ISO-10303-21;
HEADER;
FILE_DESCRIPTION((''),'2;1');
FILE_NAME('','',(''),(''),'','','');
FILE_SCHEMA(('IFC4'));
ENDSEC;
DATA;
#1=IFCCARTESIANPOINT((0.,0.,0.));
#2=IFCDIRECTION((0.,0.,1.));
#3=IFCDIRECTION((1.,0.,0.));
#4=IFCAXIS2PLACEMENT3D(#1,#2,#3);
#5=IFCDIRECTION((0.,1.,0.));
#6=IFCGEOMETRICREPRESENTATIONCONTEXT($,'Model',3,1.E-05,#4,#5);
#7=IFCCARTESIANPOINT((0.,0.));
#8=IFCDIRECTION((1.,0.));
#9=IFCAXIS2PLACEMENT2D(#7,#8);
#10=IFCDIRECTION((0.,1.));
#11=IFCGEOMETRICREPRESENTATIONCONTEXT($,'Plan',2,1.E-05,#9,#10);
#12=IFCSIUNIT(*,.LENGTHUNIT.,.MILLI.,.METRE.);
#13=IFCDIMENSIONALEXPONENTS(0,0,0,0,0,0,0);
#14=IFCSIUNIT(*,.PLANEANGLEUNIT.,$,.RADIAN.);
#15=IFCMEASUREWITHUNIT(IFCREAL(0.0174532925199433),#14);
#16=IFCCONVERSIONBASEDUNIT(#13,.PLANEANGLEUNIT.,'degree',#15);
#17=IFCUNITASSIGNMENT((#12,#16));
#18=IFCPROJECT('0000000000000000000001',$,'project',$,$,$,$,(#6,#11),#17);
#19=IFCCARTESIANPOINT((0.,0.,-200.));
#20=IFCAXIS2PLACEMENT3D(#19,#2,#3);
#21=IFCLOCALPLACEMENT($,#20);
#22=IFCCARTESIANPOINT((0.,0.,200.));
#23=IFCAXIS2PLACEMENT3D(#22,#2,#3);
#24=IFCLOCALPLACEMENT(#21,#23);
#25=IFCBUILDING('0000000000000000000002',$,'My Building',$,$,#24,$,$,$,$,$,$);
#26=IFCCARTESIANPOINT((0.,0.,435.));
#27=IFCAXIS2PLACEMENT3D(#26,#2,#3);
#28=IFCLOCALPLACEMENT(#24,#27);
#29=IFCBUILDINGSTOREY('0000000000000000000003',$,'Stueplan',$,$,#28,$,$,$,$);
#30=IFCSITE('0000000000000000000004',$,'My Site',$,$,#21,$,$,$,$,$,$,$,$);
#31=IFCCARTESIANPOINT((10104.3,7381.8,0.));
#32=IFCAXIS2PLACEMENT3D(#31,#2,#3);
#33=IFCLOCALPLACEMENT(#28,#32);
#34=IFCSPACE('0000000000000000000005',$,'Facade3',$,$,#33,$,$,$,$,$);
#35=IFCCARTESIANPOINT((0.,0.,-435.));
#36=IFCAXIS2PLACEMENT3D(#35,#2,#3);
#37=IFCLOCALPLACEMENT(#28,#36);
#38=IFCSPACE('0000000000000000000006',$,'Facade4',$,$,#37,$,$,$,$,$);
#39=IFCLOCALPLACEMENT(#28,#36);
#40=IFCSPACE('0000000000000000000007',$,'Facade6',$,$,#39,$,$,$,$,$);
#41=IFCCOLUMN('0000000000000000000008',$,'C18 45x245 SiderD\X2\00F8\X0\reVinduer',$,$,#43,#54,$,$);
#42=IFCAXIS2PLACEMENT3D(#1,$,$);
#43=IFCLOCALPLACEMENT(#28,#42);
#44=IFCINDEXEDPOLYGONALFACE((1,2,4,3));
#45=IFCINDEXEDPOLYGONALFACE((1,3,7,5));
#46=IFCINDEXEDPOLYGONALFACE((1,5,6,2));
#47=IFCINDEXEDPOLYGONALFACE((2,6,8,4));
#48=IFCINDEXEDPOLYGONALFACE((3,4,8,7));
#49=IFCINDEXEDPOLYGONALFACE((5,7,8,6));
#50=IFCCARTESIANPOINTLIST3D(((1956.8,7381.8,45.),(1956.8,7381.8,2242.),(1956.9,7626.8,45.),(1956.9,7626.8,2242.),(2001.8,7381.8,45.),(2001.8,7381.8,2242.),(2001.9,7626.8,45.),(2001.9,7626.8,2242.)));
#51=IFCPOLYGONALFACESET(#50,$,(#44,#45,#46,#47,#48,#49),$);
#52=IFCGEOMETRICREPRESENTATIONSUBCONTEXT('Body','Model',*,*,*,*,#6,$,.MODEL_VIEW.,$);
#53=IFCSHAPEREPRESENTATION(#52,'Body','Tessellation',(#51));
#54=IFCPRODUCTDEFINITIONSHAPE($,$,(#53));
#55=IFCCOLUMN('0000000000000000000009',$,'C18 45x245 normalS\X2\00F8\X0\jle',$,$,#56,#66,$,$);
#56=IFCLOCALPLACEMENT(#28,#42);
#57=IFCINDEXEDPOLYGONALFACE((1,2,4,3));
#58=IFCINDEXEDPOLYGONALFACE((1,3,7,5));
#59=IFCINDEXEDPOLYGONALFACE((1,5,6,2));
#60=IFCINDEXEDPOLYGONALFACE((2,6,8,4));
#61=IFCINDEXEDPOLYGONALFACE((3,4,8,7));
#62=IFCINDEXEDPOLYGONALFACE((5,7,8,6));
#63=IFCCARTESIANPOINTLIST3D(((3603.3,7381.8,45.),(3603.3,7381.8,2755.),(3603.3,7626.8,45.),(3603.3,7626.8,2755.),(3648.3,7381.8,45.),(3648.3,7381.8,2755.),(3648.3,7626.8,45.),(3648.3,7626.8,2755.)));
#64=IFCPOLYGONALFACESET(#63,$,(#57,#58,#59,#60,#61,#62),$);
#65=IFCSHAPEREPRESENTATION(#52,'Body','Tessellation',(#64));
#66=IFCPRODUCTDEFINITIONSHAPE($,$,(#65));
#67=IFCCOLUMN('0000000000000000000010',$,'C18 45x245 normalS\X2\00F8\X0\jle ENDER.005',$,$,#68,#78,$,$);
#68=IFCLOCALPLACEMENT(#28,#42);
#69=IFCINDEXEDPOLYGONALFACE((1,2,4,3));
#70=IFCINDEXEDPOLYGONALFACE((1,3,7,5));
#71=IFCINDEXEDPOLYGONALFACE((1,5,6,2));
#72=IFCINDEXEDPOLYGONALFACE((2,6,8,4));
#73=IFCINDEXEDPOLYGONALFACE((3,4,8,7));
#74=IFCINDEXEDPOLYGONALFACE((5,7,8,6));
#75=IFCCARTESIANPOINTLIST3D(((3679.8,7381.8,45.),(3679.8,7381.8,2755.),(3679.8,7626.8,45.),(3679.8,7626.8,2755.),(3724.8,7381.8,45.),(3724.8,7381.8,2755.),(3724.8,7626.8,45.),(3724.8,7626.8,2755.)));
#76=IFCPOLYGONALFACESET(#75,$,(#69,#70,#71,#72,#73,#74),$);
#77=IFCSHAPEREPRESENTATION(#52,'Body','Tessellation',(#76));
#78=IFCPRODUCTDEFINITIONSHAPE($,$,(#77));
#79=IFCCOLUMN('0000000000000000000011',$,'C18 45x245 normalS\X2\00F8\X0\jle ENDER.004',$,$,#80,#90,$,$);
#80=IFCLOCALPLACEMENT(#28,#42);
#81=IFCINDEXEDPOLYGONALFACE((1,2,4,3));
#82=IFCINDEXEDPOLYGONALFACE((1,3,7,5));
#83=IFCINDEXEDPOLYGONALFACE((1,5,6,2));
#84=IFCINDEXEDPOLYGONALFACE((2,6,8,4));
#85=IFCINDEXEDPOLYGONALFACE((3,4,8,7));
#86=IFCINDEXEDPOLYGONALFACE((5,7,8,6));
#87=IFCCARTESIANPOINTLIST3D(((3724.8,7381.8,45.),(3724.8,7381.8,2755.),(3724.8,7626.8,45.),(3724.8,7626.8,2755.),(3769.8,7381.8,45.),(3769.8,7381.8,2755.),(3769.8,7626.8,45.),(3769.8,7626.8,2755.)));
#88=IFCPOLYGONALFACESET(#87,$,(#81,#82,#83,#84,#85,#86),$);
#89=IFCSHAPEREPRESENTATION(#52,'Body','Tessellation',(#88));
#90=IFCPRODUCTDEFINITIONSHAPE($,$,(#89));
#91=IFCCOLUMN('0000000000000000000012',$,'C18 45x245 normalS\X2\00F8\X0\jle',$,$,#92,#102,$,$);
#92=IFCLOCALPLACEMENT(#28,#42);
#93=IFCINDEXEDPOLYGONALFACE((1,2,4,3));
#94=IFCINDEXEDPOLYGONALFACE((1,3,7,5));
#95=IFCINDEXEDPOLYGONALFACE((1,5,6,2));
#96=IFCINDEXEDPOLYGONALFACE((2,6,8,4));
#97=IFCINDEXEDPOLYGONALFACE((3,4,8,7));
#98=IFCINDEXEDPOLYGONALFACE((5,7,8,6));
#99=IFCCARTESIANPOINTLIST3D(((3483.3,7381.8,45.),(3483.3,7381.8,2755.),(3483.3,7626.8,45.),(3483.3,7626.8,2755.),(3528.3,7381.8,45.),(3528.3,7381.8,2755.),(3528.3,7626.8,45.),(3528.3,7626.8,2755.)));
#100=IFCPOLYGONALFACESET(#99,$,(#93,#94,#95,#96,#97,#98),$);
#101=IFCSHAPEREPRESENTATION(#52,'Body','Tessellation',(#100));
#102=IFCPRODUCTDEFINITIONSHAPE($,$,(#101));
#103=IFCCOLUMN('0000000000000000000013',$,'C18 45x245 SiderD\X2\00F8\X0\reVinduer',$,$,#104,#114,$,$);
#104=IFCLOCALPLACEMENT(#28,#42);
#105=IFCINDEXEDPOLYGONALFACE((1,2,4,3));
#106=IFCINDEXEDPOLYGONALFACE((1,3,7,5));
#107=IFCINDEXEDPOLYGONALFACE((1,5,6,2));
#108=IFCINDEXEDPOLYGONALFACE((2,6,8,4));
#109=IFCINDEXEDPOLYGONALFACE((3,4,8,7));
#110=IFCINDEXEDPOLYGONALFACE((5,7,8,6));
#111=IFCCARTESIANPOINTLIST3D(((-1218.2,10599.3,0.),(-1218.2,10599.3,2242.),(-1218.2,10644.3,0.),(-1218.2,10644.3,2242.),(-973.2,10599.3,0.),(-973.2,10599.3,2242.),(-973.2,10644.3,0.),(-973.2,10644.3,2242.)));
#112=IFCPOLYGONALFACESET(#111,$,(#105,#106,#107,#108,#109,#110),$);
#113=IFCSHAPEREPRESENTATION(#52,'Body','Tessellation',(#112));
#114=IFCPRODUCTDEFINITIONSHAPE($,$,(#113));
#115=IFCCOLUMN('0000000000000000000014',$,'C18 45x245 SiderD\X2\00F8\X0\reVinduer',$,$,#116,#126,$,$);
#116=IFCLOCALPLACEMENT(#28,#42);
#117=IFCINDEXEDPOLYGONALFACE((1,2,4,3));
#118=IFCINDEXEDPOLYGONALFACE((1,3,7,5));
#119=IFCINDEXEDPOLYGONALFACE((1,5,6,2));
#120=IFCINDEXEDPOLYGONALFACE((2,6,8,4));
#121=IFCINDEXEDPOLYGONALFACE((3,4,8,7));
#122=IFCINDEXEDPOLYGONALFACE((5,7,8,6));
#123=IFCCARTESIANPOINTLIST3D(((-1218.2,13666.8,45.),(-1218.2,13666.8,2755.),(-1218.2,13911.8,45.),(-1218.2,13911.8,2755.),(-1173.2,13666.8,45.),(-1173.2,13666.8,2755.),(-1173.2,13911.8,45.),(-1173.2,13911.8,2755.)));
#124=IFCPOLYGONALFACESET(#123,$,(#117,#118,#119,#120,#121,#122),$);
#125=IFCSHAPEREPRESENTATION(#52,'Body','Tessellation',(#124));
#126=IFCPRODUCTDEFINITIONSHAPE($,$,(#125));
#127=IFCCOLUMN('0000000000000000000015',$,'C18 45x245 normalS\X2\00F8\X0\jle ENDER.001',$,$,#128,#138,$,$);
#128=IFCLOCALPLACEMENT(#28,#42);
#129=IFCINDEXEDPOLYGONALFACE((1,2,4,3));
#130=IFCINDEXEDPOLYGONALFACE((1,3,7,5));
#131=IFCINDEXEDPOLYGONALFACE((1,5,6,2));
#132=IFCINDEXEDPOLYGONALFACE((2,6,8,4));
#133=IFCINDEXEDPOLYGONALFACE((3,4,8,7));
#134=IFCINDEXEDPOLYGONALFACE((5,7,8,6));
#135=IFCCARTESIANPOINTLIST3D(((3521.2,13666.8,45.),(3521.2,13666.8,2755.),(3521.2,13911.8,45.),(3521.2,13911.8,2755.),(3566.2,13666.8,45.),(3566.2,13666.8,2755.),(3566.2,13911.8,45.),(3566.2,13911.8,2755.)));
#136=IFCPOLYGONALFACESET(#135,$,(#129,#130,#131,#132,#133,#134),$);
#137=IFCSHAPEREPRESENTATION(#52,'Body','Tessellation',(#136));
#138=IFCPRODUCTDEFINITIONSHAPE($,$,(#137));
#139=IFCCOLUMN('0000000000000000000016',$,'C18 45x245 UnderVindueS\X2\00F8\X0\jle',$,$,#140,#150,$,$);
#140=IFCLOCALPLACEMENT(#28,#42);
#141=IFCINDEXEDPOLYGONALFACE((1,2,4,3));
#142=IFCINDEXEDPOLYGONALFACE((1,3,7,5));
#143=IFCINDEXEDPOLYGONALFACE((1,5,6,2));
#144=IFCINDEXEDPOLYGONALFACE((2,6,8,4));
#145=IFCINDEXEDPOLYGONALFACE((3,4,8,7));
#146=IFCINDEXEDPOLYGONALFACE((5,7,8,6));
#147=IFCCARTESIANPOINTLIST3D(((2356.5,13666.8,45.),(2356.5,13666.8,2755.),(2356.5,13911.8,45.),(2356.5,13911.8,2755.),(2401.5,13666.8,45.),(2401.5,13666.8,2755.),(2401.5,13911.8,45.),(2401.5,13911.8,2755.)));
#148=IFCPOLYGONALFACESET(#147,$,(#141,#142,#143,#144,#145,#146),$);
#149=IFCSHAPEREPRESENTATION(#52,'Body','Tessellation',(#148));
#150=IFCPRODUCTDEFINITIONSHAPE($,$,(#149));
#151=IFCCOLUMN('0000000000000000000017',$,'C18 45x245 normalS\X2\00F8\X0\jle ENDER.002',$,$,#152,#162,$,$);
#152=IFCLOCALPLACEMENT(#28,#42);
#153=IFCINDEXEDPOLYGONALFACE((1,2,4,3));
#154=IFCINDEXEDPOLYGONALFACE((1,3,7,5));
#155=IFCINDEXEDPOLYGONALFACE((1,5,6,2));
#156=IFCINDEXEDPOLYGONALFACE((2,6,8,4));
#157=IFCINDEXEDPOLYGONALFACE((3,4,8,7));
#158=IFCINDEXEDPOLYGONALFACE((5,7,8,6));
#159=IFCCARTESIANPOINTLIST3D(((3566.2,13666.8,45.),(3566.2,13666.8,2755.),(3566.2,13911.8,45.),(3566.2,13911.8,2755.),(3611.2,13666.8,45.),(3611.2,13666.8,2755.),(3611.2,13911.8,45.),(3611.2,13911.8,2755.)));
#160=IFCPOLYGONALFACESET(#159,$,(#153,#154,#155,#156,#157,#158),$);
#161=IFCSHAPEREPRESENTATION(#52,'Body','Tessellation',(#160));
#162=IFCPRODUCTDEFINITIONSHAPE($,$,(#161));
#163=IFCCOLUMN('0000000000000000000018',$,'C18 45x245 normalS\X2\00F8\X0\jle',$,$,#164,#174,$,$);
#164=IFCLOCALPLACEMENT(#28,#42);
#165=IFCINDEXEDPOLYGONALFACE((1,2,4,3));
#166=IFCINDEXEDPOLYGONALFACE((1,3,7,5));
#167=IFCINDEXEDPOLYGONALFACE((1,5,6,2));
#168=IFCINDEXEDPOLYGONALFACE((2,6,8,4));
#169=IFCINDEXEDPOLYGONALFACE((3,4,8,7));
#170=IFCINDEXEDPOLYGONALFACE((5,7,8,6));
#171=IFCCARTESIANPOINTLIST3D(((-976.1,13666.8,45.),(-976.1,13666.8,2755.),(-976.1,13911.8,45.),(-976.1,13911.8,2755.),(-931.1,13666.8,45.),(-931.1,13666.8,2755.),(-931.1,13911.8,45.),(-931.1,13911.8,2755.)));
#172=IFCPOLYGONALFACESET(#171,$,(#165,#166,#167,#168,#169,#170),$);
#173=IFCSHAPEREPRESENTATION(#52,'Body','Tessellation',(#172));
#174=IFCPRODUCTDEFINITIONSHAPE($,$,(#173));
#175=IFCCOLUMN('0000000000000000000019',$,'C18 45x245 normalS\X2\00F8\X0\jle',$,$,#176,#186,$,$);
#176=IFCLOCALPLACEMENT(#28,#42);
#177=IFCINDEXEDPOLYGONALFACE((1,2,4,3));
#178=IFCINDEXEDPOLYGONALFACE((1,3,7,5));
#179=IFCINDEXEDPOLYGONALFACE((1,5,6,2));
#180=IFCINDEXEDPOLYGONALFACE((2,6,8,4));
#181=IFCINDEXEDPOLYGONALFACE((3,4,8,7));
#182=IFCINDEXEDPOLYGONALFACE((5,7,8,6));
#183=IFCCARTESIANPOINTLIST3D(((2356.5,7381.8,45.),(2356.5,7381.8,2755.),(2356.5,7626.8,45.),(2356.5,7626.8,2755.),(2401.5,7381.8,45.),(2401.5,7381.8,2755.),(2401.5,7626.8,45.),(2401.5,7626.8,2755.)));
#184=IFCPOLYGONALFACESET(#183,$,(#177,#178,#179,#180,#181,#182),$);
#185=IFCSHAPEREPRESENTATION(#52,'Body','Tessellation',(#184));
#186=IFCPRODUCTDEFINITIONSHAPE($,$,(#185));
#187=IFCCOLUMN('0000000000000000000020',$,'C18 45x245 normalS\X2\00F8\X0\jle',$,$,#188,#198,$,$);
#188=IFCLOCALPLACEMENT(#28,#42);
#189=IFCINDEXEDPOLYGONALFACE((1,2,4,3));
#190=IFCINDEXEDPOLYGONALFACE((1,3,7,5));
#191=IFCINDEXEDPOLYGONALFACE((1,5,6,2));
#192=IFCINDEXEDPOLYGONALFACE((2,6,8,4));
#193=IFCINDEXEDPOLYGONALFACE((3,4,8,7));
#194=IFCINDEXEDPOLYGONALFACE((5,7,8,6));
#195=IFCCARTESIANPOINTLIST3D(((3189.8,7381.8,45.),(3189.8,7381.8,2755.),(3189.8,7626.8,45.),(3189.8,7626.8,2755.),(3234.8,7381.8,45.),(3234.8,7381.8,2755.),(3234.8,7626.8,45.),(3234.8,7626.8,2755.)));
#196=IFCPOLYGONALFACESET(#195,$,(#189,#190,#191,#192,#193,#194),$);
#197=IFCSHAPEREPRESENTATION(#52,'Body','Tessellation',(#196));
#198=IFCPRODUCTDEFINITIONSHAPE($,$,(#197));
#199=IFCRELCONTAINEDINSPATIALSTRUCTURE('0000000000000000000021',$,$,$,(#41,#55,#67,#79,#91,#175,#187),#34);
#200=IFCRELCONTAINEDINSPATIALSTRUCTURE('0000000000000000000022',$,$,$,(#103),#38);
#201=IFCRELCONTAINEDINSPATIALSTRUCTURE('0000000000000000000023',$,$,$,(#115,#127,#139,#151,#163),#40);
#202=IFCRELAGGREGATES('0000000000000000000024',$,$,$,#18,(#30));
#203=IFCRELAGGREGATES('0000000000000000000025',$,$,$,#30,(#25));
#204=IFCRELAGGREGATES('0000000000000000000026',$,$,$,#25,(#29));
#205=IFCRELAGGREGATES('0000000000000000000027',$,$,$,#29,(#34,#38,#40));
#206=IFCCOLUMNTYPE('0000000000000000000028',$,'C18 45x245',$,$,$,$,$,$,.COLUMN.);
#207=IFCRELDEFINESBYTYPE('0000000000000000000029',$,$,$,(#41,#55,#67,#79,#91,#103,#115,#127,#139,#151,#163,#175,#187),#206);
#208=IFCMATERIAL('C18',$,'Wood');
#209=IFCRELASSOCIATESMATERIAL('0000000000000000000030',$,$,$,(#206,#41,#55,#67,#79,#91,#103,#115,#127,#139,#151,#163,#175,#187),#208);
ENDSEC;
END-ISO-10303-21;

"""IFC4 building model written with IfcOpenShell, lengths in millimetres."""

from ifc_helpers import new_model, entity, si_unit, converted_unit, direction, frame, origin_with_axes, origin_2d_with_axis, place, context, subcontext, project, spatial, rectangle, extrude, material, material_profile, profile_set, profile_usage, type_object, element, save


model = new_model("IFC4")

# Units and contexts
model_context = context("Model", 3, precision=1e-05, world=origin_with_axes(), true_north=direction((0.0, 1.0, 0.0)))
plan_context = context("Plan", 2, precision=1e-05, world=origin_2d_with_axis(), true_north=direction((0.0, 1.0)))
body_context_1 = subcontext(model_context, "Body", "Model", "MODEL_VIEW")
ifc_project = project(units=[si_unit("LENGTHUNIT", "METRE", prefix="MILLI"), converted_unit("PLANEANGLEUNIT", "degree", entity("IfcReal", 0.0174532925199433), si_unit("PLANEANGLEUNIT", "RADIAN"), dimensions=[0, 0, 0, 0, 0, 0, 0])], contexts=[model_context, plan_context])

# Site, building, storey, space
site_placement = place(None, frame((0.0, 0.0, -200.0), z_axis=(0.0, 0.0, 1.0), x_axis=(1.0, 0.0, 0.0)))
site = spatial("IfcSite", under=ifc_project, at=site_placement, Name="My Site")
building_placement = place(site_placement, frame((0.0, 0.0, 200.0), z_axis=(0.0, 0.0, 1.0), x_axis=(1.0, 0.0, 0.0)))
building = spatial("IfcBuilding", under=site, at=building_placement, Name="My Building")
storey_placement = place(building_placement, frame((0.0, 0.0, 435.0), z_axis=(0.0, 0.0, 1.0), x_axis=(1.0, 0.0, 0.0)))
storey = spatial("IfcBuildingStorey", under=building, at=storey_placement, Name="Stueplan")
space_1_placement = place(storey_placement, frame((10104.3, 7381.8, 0.0), z_axis=(0.0, 0.0, 1.0), x_axis=(1.0, 0.0, 0.0)))
space_1 = spatial("IfcSpace", under=storey, at=space_1_placement, Name="Facade3")

# Columns
ifc_material_1 = material(Name="C18", Category="Wood")
ifc_material_profile_1 = material_profile(ifc_material_1, rectangle(XDim=45.0, YDim=245.0))
ifc_profile_set_1 = profile_set([ifc_material_profile_1], Name="woodStructural")
ifc_profile_usage_1 = profile_usage(ifc_profile_set_1, cardinal=9)
column_type = type_object("IfcColumnType", Name="C18 45x245", PredefinedType="COLUMN", material=ifc_profile_set_1)
column_1_placement = place(space_1_placement, frame((-8147.5, 245.0, 45.0), z_axis=(0.0, 0.0, 1.0), x_axis=(1.0, 0.0, 0.0)))
element("IfcColumn", 1, at=column_1_placement, inside=space_1, type_object=column_type, material=ifc_profile_usage_1, Name="C18 45x245 SiderDøreVinduer", context=body_context_1, shape_type="SweptSolid", body=[
    extrude(rectangle(XDim=45.0, YDim=245.0), frame((22.5, -122.5, 0.0), z_axis=(0.0, 0.0, 1.0), x_axis=(1.0, 0.0, 0.0)), (0.0, 0.0, 1.0), 2197.0),
])
ifc_profile_usage_2 = profile_usage(ifc_profile_set_1, cardinal=9)
column_2_placement = place(space_1_placement, frame((-6501.1, 245.0, 45.0), z_axis=(0.0, 0.0, 1.0), x_axis=(1.0, 0.0, 0.0)))
element("IfcColumn", 2, at=column_2_placement, inside=space_1, type_object=column_type, material=ifc_profile_usage_2, Name="C18 45x245 normalSøjle", context=body_context_1, shape_type="SweptSolid", body=[
    extrude(rectangle(XDim=45.0, YDim=245.0), frame((22.5, -122.5, 0.0), z_axis=(0.0, 0.0, 1.0), x_axis=(1.0, 0.0, 0.0)), (0.0, 0.0, 1.0), 2710.0),
])
ifc_profile_usage_3 = profile_usage(ifc_profile_set_1, cardinal=9)
column_3_placement = place(space_1_placement, frame((-6424.6, 245.0, 45.0), z_axis=(0.0, 0.0, 1.0), x_axis=(1.0, 0.0, 0.0)))
element("IfcColumn", 3, at=column_3_placement, inside=space_1, type_object=column_type, material=ifc_profile_usage_3, Name="C18 45x245 normalSøjle ENDER.005", context=body_context_1, shape_type="SweptSolid", body=[
    extrude(rectangle(XDim=45.0, YDim=245.0), frame((22.5, -122.5, 0.0), z_axis=(0.0, 0.0, 1.0), x_axis=(1.0, 0.0, 0.0)), (0.0, 0.0, 1.0), 2710.0),
])
ifc_profile_usage_4 = profile_usage(ifc_profile_set_1, cardinal=9)
column_4_placement = place(space_1_placement, frame((-6379.6, 245.0, 45.0), z_axis=(0.0, 0.0, 1.0), x_axis=(1.0, 0.0, 0.0)))
element("IfcColumn", 4, at=column_4_placement, inside=space_1, type_object=column_type, material=ifc_profile_usage_4, Name="C18 45x245 normalSøjle ENDER.004", context=body_context_1, shape_type="SweptSolid", body=[
    extrude(rectangle(XDim=45.0, YDim=245.0), frame((22.5, -122.5, 0.0), z_axis=(0.0, 0.0, 1.0), x_axis=(1.0, 0.0, 0.0)), (0.0, 0.0, 1.0), 2710.0),
])
ifc_profile_usage_5 = profile_usage(ifc_profile_set_1, cardinal=9)
column_5_placement = place(space_1_placement, frame((-6621.1, 245.0, 45.0), z_axis=(0.0, 0.0, 1.0), x_axis=(1.0, 0.0, 0.0)))
element("IfcColumn", 5, at=column_5_placement, inside=space_1, type_object=column_type, material=ifc_profile_usage_5, Name="C18 45x245 normalSøjle", context=body_context_1, shape_type="SweptSolid", body=[
    extrude(rectangle(XDim=45.0, YDim=245.0), frame((22.5, -122.5, 0.0), z_axis=(0.0, 0.0, 1.0), x_axis=(1.0, 0.0, 0.0)), (0.0, 0.0, 1.0), 2710.0),
])

# Shared definitions
space_2_placement = place(storey_placement, frame((0.0, 0.0, -435.0), z_axis=(0.0, 0.0, 1.0), x_axis=(1.0, 0.0, 0.0)))
space_2 = spatial("IfcSpace", under=storey, at=space_2_placement, Name="Facade4")

# Column
ifc_profile_usage_6 = profile_usage(ifc_profile_set_1, cardinal=9)
column_6_placement = place(space_2_placement, frame((-1218.2, 10599.3, 435.0), z_axis=(0.0, 0.0, 1.0), x_axis=(0.0, 1.0, 0.0)))
element("IfcColumn", 6, at=column_6_placement, inside=space_2, type_object=column_type, material=ifc_profile_usage_6, Name="C18 45x245 SiderDøreVinduer", context=body_context_1, shape_type="SweptSolid", body=[
    extrude(rectangle(XDim=45.0, YDim=245.0), frame((22.5, -122.5, 0.0), z_axis=(0.0, 0.0, 1.0), x_axis=(1.0, 0.0, 0.0)), (0.0, 0.0, 1.0), 2242.0),
])

# Shared definitions
space_3_placement = place(storey_placement, frame((0.0, 0.0, -435.0), z_axis=(0.0, 0.0, 1.0), x_axis=(1.0, 0.0, 0.0)))
space_3 = spatial("IfcSpace", under=storey, at=space_3_placement, Name="Facade6")

# Columns
ifc_profile_usage_7 = profile_usage(ifc_profile_set_1, cardinal=9)
column_7_placement = place(space_3_placement, frame((-1218.2, 13911.8, 480.0), z_axis=(0.0, 0.0, 1.0), x_axis=(1.0, 0.0, 0.0)))
element("IfcColumn", 7, at=column_7_placement, inside=space_3, type_object=column_type, material=ifc_profile_usage_7, Name="C18 45x245 SiderDøreVinduer", context=body_context_1, shape_type="SweptSolid", body=[
    extrude(rectangle(XDim=45.0, YDim=245.0), frame((22.5, -122.5, 0.0), z_axis=(0.0, 0.0, 1.0), x_axis=(1.0, 0.0, 0.0)), (0.0, 0.0, 1.0), 2710.0),
])
ifc_profile_usage_8 = profile_usage(ifc_profile_set_1, cardinal=9)
column_8_placement = place(space_3_placement, frame((3521.2, 13911.8, 480.0), z_axis=(0.0, 0.0, 1.0), x_axis=(1.0, 0.0, 0.0)))
element("IfcColumn", 8, at=column_8_placement, inside=space_3, type_object=column_type, material=ifc_profile_usage_8, Name="C18 45x245 normalSøjle ENDER.001", context=body_context_1, shape_type="SweptSolid", body=[
    extrude(rectangle(XDim=45.0, YDim=245.0), frame((22.5, -122.5, 0.0), z_axis=(0.0, 0.0, 1.0), x_axis=(1.0, 0.0, 0.0)), (0.0, 0.0, 1.0), 2710.0),
])
ifc_profile_usage_9 = profile_usage(ifc_profile_set_1, cardinal=9)
column_9_placement = place(space_3_placement, frame((2356.5, 13911.8, 480.0), z_axis=(0.0, 0.0, 1.0), x_axis=(1.0, 0.0, 0.0)))
element("IfcColumn", 9, at=column_9_placement, inside=space_3, type_object=column_type, material=ifc_profile_usage_9, Name="C18 45x245 UnderVindueSøjle", context=body_context_1, shape_type="SweptSolid", body=[
    extrude(rectangle(XDim=45.0, YDim=245.0), frame((22.5, -122.5, 0.0), z_axis=(0.0, 0.0, 1.0), x_axis=(1.0, 0.0, 0.0)), (0.0, 0.0, 1.0), 2710.0),
])
ifc_profile_usage_10 = profile_usage(ifc_profile_set_1, cardinal=9)
column_10_placement = place(space_3_placement, frame((3566.2, 13911.8, 480.0), z_axis=(0.0, 0.0, 1.0), x_axis=(1.0, 0.0, 0.0)))
element("IfcColumn", 10, at=column_10_placement, inside=space_3, type_object=column_type, material=ifc_profile_usage_10, Name="C18 45x245 normalSøjle ENDER.002", context=body_context_1, shape_type="SweptSolid", body=[
    extrude(rectangle(XDim=45.0, YDim=245.0), frame((22.5, -122.5, 0.0), z_axis=(0.0, 0.0, 1.0), x_axis=(1.0, 0.0, 0.0)), (0.0, 0.0, 1.0), 2710.0),
])
ifc_profile_usage_11 = profile_usage(ifc_profile_set_1, cardinal=9)
column_11_placement = place(space_3_placement, frame((-976.1, 13911.8, 480.0), z_axis=(0.0, 0.0, 1.0), x_axis=(1.0, 0.0, 0.0)))
element("IfcColumn", 11, at=column_11_placement, inside=space_3, type_object=column_type, material=ifc_profile_usage_11, Name="C18 45x245 normalSøjle", context=body_context_1, shape_type="SweptSolid", body=[
    extrude(rectangle(XDim=45.0, YDim=245.0), frame((22.5, -122.5, 0.0), z_axis=(0.0, 0.0, 1.0), x_axis=(1.0, 0.0, 0.0)), (0.0, 0.0, 1.0), 2710.0),
])
ifc_profile_usage_12 = profile_usage(ifc_profile_set_1, cardinal=9)
column_12_placement = place(space_1_placement, frame((-7747.9, 245.0, 45.0), z_axis=(0.0, 0.0, 1.0), x_axis=(1.0, 0.0, 0.0)))
element("IfcColumn", 12, at=column_12_placement, inside=space_1, type_object=column_type, material=ifc_profile_usage_12, Name="C18 45x245 normalSøjle", context=body_context_1, shape_type="SweptSolid", body=[
    extrude(rectangle(XDim=45.0, YDim=245.0), frame((22.5, -122.5, 0.0), z_axis=(0.0, 0.0, 1.0), x_axis=(1.0, 0.0, 0.0)), (0.0, 0.0, 1.0), 2710.0),
])
ifc_profile_usage_13 = profile_usage(ifc_profile_set_1, cardinal=9)
column_13_placement = place(space_1_placement, frame((-6914.5, 245.0, 45.0), z_axis=(0.0, 0.0, 1.0), x_axis=(1.0, 0.0, 0.0)))
element("IfcColumn", 13, at=column_13_placement, inside=space_1, type_object=column_type, material=ifc_profile_usage_13, Name="C18 45x245 normalSøjle", context=body_context_1, shape_type="SweptSolid", body=[
    extrude(rectangle(XDim=45.0, YDim=245.0), frame((22.5, -122.5, 0.0), z_axis=(0.0, 0.0, 1.0), x_axis=(1.0, 0.0, 0.0)), (0.0, 0.0, 1.0), 2710.0),
])

save(model, "model.ifc")
